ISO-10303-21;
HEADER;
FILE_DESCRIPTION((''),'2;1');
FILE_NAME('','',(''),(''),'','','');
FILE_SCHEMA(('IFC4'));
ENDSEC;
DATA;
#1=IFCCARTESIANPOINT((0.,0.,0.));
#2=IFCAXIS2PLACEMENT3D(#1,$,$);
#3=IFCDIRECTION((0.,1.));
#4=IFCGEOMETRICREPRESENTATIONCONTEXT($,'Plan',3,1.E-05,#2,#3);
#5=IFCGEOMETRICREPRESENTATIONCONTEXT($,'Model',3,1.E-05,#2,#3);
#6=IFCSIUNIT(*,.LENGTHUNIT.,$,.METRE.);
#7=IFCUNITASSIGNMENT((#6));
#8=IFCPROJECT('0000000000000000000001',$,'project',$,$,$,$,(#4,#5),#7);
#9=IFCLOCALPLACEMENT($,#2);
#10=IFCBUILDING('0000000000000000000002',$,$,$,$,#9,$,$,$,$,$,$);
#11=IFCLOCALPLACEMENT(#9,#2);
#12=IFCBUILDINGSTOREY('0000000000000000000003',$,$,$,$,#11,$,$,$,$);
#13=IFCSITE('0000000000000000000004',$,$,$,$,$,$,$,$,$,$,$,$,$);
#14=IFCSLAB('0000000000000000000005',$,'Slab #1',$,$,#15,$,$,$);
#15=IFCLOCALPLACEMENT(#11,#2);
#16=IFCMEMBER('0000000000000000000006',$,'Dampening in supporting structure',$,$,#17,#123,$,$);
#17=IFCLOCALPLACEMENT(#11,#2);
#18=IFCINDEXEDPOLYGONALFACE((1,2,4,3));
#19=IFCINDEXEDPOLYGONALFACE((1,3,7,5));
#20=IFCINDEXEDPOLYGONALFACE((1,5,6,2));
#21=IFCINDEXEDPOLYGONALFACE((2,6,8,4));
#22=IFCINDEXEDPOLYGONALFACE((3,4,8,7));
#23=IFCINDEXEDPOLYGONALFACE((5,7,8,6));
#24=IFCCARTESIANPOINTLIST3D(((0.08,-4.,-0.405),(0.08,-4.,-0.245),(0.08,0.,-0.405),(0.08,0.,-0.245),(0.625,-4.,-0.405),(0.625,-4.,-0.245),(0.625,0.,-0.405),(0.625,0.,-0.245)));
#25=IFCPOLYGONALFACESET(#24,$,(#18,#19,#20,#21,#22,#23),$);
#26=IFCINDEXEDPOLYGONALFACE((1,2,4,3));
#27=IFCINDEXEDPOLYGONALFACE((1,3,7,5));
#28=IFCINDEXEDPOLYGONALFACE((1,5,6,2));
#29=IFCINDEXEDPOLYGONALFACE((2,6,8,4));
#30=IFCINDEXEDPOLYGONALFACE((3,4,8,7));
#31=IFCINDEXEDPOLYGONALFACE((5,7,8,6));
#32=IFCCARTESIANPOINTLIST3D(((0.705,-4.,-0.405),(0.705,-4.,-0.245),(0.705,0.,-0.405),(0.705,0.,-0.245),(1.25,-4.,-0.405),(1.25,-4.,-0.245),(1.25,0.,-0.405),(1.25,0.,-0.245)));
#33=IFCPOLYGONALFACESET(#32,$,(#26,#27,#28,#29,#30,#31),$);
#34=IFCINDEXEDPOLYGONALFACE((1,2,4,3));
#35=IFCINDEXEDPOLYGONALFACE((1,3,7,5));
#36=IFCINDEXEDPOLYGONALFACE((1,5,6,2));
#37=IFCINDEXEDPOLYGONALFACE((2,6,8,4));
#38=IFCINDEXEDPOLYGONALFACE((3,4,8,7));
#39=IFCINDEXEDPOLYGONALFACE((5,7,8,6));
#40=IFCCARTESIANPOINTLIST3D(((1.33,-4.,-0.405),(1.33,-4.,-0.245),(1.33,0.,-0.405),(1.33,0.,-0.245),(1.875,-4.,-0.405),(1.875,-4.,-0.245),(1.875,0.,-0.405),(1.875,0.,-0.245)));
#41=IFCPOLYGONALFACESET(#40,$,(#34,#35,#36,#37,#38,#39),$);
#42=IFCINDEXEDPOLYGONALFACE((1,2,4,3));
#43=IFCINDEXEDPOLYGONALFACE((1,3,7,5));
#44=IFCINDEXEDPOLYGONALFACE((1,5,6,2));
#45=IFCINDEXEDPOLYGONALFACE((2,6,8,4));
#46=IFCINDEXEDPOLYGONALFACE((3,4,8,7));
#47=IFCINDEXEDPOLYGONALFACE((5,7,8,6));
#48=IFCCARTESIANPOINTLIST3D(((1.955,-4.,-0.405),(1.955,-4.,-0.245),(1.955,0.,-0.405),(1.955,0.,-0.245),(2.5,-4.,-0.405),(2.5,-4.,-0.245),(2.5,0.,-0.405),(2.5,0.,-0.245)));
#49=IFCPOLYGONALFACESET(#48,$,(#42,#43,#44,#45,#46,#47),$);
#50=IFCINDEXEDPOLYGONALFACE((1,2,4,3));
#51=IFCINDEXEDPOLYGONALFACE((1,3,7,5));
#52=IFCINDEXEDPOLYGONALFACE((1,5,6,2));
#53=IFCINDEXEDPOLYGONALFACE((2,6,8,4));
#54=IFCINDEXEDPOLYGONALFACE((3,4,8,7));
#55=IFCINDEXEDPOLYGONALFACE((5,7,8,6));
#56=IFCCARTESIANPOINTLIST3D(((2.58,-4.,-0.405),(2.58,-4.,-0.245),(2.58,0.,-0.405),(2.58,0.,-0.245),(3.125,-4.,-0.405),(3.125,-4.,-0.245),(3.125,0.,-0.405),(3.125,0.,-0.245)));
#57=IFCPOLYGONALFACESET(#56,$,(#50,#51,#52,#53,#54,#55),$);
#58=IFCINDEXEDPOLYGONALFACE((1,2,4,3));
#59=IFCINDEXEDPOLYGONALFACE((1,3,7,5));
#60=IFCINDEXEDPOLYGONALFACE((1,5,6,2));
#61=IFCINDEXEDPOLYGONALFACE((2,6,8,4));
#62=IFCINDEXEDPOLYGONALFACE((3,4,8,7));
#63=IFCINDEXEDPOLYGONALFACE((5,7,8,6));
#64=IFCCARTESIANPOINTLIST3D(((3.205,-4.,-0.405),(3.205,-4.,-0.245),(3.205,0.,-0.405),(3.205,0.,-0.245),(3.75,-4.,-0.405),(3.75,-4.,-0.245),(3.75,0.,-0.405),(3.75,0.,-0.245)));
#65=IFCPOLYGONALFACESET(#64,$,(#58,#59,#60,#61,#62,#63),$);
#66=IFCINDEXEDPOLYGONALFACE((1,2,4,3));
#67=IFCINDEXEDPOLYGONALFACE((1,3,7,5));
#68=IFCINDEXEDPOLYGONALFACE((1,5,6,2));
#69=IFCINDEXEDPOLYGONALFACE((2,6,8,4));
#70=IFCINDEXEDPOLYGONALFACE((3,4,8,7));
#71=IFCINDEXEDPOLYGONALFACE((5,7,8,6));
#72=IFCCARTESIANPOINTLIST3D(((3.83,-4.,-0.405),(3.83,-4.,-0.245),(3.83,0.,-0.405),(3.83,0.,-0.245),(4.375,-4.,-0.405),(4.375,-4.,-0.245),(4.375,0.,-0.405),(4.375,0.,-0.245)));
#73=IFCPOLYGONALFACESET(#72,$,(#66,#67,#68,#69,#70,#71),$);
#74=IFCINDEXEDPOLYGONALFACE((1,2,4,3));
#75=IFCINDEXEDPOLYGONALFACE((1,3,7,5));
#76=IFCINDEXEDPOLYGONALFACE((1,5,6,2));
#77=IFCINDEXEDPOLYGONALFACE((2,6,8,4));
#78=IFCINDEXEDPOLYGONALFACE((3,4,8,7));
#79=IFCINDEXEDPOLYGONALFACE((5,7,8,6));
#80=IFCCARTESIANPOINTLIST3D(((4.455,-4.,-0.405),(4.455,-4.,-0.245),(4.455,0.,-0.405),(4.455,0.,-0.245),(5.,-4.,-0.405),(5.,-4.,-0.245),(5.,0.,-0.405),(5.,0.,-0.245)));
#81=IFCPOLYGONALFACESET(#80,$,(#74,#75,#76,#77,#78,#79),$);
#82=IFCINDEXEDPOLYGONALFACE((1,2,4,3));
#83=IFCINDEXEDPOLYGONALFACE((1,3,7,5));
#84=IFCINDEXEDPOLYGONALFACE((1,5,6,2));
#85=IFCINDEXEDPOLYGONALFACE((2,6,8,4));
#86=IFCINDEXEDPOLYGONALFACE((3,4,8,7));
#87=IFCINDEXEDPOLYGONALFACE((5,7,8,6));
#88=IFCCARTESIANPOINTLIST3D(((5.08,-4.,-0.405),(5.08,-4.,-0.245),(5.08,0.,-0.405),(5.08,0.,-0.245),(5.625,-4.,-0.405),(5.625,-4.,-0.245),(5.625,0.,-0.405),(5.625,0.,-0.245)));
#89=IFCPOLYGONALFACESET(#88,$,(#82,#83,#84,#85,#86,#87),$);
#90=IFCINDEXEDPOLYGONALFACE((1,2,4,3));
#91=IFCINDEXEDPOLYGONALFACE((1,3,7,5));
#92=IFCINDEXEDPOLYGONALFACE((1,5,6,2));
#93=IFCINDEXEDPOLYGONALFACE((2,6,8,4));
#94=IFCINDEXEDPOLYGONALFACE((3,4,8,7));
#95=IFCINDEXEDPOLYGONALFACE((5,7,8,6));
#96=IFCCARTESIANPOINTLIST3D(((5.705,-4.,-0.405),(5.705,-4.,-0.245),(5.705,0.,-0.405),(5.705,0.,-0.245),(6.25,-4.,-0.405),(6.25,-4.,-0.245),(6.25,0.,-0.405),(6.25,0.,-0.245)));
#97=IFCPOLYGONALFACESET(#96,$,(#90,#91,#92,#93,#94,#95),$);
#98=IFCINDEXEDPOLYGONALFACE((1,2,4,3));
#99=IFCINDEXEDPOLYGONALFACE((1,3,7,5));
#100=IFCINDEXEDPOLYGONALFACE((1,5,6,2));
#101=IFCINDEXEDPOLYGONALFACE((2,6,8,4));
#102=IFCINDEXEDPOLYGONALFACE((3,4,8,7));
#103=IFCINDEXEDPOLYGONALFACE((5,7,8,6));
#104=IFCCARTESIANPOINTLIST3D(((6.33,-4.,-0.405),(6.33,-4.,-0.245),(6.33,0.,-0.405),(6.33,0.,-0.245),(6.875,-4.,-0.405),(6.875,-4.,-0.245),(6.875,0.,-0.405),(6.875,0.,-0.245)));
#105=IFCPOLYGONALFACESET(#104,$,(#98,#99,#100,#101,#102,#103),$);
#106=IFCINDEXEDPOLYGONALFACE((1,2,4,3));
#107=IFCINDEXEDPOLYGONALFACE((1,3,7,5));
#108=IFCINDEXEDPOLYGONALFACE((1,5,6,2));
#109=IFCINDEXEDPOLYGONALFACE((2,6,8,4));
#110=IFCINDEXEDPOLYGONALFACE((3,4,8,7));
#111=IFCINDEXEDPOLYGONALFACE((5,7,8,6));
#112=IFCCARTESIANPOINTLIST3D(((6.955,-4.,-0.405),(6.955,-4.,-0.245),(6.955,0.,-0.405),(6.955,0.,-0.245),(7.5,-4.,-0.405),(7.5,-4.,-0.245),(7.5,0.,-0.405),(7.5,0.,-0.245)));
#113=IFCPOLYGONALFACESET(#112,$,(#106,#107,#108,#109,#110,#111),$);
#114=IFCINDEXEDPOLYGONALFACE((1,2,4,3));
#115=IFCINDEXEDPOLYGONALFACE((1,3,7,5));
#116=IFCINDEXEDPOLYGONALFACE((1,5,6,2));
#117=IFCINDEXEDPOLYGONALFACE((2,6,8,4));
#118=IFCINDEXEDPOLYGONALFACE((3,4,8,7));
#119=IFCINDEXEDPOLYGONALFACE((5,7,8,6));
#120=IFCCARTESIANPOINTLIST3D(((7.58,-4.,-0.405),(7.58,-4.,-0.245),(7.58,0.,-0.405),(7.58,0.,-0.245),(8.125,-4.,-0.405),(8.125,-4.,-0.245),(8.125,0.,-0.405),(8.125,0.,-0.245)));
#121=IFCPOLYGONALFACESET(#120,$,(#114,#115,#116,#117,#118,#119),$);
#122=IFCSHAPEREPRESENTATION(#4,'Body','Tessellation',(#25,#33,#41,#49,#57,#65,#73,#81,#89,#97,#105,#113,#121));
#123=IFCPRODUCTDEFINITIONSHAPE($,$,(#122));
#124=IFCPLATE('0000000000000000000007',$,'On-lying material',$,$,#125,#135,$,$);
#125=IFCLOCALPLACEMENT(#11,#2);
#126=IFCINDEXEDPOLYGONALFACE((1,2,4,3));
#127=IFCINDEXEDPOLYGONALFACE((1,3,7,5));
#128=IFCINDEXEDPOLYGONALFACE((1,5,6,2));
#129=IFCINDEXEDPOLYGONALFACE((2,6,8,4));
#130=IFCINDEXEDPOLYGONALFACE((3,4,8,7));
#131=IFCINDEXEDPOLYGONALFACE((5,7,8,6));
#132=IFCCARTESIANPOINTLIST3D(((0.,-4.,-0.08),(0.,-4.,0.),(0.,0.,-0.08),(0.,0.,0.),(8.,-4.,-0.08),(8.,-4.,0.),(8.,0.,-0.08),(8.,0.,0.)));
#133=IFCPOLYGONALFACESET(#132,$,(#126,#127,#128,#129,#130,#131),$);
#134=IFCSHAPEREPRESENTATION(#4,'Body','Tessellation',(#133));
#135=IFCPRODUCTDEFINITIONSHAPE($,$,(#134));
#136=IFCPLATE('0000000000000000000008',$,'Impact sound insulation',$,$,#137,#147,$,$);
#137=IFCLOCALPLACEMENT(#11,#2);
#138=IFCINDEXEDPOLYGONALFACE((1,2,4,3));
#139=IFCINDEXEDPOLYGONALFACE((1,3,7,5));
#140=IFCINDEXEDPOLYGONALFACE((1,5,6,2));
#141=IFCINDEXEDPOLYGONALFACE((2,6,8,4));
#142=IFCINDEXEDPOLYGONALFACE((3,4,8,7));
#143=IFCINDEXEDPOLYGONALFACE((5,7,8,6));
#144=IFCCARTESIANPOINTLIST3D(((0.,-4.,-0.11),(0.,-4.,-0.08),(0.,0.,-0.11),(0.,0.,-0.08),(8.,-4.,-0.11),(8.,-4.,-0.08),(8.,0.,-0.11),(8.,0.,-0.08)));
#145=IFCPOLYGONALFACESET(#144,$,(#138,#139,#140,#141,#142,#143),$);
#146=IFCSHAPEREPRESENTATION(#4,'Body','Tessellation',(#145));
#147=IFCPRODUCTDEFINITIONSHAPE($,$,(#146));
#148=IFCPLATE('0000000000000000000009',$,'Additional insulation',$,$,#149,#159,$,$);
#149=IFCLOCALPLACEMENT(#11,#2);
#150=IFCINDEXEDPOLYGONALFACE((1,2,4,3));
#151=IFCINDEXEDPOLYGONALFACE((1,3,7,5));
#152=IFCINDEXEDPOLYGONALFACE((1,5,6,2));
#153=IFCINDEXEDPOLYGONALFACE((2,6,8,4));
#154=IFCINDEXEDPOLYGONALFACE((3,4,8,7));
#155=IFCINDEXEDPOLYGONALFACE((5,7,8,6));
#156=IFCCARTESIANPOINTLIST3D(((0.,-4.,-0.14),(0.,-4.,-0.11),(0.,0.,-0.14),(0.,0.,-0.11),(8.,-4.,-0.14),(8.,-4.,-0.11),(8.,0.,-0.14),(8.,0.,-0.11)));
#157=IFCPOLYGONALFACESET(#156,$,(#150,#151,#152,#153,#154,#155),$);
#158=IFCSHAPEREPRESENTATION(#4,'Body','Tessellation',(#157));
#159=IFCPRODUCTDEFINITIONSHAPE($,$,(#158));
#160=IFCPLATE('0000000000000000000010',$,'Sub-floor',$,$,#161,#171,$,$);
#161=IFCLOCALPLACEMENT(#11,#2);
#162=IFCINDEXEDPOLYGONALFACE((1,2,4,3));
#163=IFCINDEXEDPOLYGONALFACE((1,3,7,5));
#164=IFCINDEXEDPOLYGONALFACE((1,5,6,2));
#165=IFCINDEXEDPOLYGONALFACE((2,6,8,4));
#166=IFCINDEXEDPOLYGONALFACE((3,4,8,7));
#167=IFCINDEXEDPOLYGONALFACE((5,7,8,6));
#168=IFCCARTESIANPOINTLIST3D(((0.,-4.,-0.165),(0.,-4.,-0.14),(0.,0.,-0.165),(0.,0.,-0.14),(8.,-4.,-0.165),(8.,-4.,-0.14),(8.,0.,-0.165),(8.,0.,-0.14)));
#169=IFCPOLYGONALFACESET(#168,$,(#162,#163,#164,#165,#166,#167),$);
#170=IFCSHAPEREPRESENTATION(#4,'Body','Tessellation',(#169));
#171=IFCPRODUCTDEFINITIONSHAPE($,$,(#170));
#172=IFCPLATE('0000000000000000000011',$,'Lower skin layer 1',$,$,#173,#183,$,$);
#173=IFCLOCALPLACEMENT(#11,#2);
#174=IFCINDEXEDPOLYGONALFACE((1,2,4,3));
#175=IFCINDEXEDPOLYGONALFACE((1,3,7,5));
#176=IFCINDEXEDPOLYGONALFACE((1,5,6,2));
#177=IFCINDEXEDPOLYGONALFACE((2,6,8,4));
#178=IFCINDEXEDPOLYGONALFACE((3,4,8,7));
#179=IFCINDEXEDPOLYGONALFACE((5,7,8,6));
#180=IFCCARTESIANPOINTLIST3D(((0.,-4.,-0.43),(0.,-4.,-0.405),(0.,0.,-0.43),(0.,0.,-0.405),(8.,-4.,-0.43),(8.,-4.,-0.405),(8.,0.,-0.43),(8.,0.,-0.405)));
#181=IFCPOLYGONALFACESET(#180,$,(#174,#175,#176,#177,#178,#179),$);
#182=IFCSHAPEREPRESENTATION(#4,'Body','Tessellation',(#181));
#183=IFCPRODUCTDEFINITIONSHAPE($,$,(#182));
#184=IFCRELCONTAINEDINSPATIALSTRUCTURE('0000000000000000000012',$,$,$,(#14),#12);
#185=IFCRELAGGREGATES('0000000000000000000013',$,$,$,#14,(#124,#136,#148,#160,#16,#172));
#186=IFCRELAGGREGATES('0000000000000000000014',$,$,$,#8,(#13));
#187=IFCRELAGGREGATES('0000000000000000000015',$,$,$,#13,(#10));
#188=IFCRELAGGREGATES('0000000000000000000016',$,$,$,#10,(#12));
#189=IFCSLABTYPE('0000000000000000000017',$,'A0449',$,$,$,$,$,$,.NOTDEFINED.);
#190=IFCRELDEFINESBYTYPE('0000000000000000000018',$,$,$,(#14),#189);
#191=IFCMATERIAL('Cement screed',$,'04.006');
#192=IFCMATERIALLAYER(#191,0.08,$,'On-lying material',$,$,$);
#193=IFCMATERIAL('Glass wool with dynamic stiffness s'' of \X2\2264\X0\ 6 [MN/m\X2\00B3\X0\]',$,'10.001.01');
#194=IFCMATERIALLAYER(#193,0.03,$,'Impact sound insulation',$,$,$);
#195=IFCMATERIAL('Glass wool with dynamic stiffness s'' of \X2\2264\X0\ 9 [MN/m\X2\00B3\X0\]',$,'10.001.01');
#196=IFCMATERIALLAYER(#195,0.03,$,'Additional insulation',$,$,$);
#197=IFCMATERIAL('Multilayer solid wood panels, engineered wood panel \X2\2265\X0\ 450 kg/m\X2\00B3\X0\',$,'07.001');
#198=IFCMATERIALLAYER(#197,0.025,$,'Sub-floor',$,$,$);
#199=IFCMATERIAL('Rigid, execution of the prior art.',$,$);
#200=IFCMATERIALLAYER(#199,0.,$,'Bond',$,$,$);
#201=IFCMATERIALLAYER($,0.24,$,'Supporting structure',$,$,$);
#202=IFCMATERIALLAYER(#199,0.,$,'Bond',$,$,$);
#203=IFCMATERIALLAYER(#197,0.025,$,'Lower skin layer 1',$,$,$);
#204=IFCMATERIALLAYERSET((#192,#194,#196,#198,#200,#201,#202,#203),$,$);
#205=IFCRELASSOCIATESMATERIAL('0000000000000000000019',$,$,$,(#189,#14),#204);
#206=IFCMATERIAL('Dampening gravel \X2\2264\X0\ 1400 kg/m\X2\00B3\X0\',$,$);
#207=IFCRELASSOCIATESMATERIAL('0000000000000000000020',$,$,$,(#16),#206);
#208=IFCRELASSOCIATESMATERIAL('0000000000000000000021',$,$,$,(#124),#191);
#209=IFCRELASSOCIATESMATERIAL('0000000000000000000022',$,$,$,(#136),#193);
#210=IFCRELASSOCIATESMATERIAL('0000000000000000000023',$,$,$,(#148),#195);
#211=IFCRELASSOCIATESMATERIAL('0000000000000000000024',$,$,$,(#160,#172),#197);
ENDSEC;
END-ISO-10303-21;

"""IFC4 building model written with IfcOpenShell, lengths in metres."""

from ifc_helpers import new_model, si_unit, direction, frame, frame_2d, origin, origin_with_axes, place, context, project, spatial, rectangle, extrude, material, layer, layer_set, type_object, element, aggregate, save


model = new_model("IFC4")

# Units and contexts
plan_context = context("Plan", 3, precision=1e-05, world=origin(), true_north=direction((0.0, 1.0)))
model_context = context("Model", 3, precision=1e-05, world=origin(), true_north=direction((0.0, 1.0)))
ifc_project = project(units=[si_unit("LENGTHUNIT", "METRE")], contexts=[plan_context, model_context])

# Site, building, storey
site = spatial("IfcSite", under=ifc_project)
building_placement = place(None, origin())
building = spatial("IfcBuilding", under=site, at=building_placement)
storey_placement = place(building_placement, origin())
storey = spatial("IfcBuildingStorey", under=building, at=storey_placement)

# Slab, member, plates
ifc_material_1 = material(Name="Cement screed", Category="04.006")
ifc_layer_1 = layer(ifc_material_1, 0.08, Name="On-lying material")
ifc_material_2 = material(Name="Glass wool with dynamic stiffness s' of ≤ 6 [MN/m³]", Category="10.001.01")
ifc_layer_2 = layer(ifc_material_2, 0.03, Name="Impact sound insulation")
ifc_material_3 = material(Name="Glass wool with dynamic stiffness s' of ≤ 9 [MN/m³]", Category="10.001.01")
ifc_layer_3 = layer(ifc_material_3, 0.03, Name="Additional insulation")
ifc_material_4 = material(Name="Multilayer solid wood panels, engineered wood panel ≥ 450 kg/m³", Category="07.001")
ifc_layer_4 = layer(ifc_material_4, 0.025, Name="Sub-floor")
ifc_material_5 = material(Name="Rigid, execution of the prior art.")
ifc_layer_5 = layer(ifc_material_5, 0.0, Name="Bond")
ifc_layer_6 = layer(None, 0.24, Name="Supporting structure")
ifc_layer_7 = layer(ifc_material_5, 0.0, Name="Bond")
ifc_layer_8 = layer(ifc_material_4, 0.025, Name="Lower skin layer 1")
ifc_layer_set = layer_set([ifc_layer_1, ifc_layer_2, ifc_layer_3, ifc_layer_4, ifc_layer_5, ifc_layer_6, ifc_layer_7, ifc_layer_8])
slab_type = type_object("IfcSlabType", Name="A0449", PredefinedType="NOTDEFINED", material=ifc_layer_set)
slab_placement = place(None, frame((0.0, 0.0, 0.0), z_axis=(0.0, 0.0, -1.0), x_axis=(1.0, 0.0, 0.0)))
slab = element("IfcSlab", 1, at=slab_placement, inside=storey, type_object=slab_type, material=ifc_layer_set, Name="Slab #1")
ifc_material_6 = material(Name="Dampening gravel ≤ 1400 kg/m³")
member_1_placement = place(slab_placement, origin())
member_1 = element("IfcMember", 2, at=member_1_placement, material=ifc_material_6, Name="Dampening in supporting structure", context=plan_context, shape_type="SweptSolid", body=[
    extrude(rectangle(XDim=0.545, YDim=0.16, at=frame_2d((0.2725, 0.08), x_axis=(1.0, 0.0))), frame((0.08, 4.0, 0.245), z_axis=(0.0, -1.0, 0.0), x_axis=(1.0, 0.0, 0.0)), (0.0, 0.0, 1.0), 4.0),
    extrude(rectangle(XDim=0.545, YDim=0.16, at=frame_2d((0.2725, 0.08), x_axis=(1.0, 0.0))), frame((0.705, 4.0, 0.245), z_axis=(0.0, -1.0, 0.0), x_axis=(1.0, 0.0, 0.0)), (0.0, 0.0, 1.0), 4.0),
    extrude(rectangle(XDim=0.545, YDim=0.16, at=frame_2d((0.2725, 0.08), x_axis=(1.0, 0.0))), frame((1.33, 4.0, 0.245), z_axis=(0.0, -1.0, 0.0), x_axis=(1.0, 0.0, 0.0)), (0.0, 0.0, 1.0), 4.0),
    extrude(rectangle(XDim=0.545, YDim=0.16, at=frame_2d((0.2725, 0.08), x_axis=(1.0, 0.0))), frame((1.955, 4.0, 0.245), z_axis=(0.0, -1.0, 0.0), x_axis=(1.0, 0.0, 0.0)), (0.0, 0.0, 1.0), 4.0),
    extrude(rectangle(XDim=0.545, YDim=0.16, at=frame_2d((0.2725, 0.08), x_axis=(1.0, 0.0))), frame((2.58, 4.0, 0.245), z_axis=(0.0, -1.0, 0.0), x_axis=(1.0, 0.0, 0.0)), (0.0, 0.0, 1.0), 4.0),
    extrude(rectangle(XDim=0.545, YDim=0.16, at=frame_2d((0.2725, 0.08), x_axis=(1.0, 0.0))), frame((3.205, 4.0, 0.245), z_axis=(0.0, -1.0, 0.0), x_axis=(1.0, 0.0, 0.0)), (0.0, 0.0, 1.0), 4.0),
    extrude(rectangle(XDim=0.545, YDim=0.16, at=frame_2d((0.2725, 0.08), x_axis=(1.0, 0.0))), frame((3.83, 4.0, 0.245), z_axis=(0.0, -1.0, 0.0), x_axis=(1.0, 0.0, 0.0)), (0.0, 0.0, 1.0), 4.0),
    extrude(rectangle(XDim=0.545, YDim=0.16, at=frame_2d((0.2725, 0.08), x_axis=(1.0, 0.0))), frame((4.455, 4.0, 0.245), z_axis=(0.0, -1.0, 0.0), x_axis=(1.0, 0.0, 0.0)), (0.0, 0.0, 1.0), 4.0),
    extrude(rectangle(XDim=0.545, YDim=0.16, at=frame_2d((0.2725, 0.08), x_axis=(1.0, 0.0))), frame((5.08, 4.0, 0.245), z_axis=(0.0, -1.0, 0.0), x_axis=(1.0, 0.0, 0.0)), (0.0, 0.0, 1.0), 4.0),
    extrude(rectangle(XDim=0.545, YDim=0.16, at=frame_2d((0.2725, 0.08), x_axis=(1.0, 0.0))), frame((5.705, 4.0, 0.245), z_axis=(0.0, -1.0, 0.0), x_axis=(1.0, 0.0, 0.0)), (0.0, 0.0, 1.0), 4.0),
    extrude(rectangle(XDim=0.545, YDim=0.16, at=frame_2d((0.2725, 0.08), x_axis=(1.0, 0.0))), frame((6.33, 4.0, 0.245), z_axis=(0.0, -1.0, 0.0), x_axis=(1.0, 0.0, 0.0)), (0.0, 0.0, 1.0), 4.0),
    extrude(rectangle(XDim=0.545, YDim=0.16, at=frame_2d((0.2725, 0.08), x_axis=(1.0, 0.0))), frame((6.955, 4.0, 0.245), z_axis=(0.0, -1.0, 0.0), x_axis=(1.0, 0.0, 0.0)), (0.0, 0.0, 1.0), 4.0),
    extrude(rectangle(XDim=0.545, YDim=0.16, at=frame_2d((0.2725, 0.08), x_axis=(1.0, 0.0))), frame((7.58, 4.0, 0.245), z_axis=(0.0, -1.0, 0.0), x_axis=(1.0, 0.0, 0.0)), (0.0, 0.0, 1.0), 4.0),
])
plate_1_placement = place(slab_placement, origin())
plate_1 = element("IfcPlate", 3, at=plate_1_placement, material=ifc_material_1, Name="On-lying material", context=plan_context, shape_type="SweptSolid", body=[
    extrude(rectangle(XDim=8.0, YDim=4.0, at=frame_2d((4.0, 2.0), x_axis=(1.0, 0.0))), origin_with_axes(), (0.0, 0.0, 1.0), 0.08),
])
plate_2_placement = place(slab_placement, origin())
plate_2 = element("IfcPlate", 4, at=plate_2_placement, material=ifc_material_2, Name="Impact sound insulation", context=plan_context, shape_type="SweptSolid", body=[
    extrude(rectangle(XDim=8.0, YDim=4.0, at=frame_2d((4.0, 2.0), x_axis=(1.0, 0.0))), frame((0.0, 0.0, 0.08), z_axis=(0.0, 0.0, 1.0), x_axis=(1.0, 0.0, 0.0)), (0.0, 0.0, 1.0), 0.03),
])
plate_3_placement = place(slab_placement, origin())
plate_3 = element("IfcPlate", 5, at=plate_3_placement, material=ifc_material_3, Name="Additional insulation", context=plan_context, shape_type="SweptSolid", body=[
    extrude(rectangle(XDim=8.0, YDim=4.0, at=frame_2d((4.0, 2.0), x_axis=(1.0, 0.0))), frame((0.0, 0.0, 0.11), z_axis=(0.0, 0.0, 1.0), x_axis=(1.0, 0.0, 0.0)), (0.0, 0.0, 1.0), 0.03),
])
plate_4_placement = place(slab_placement, origin())
plate_4 = element("IfcPlate", 6, at=plate_4_placement, material=ifc_material_4, Name="Sub-floor", context=plan_context, shape_type="SweptSolid", body=[
    extrude(rectangle(XDim=8.0, YDim=4.0, at=frame_2d((4.0, 2.0), x_axis=(1.0, 0.0))), frame((0.0, 0.0, 0.14), z_axis=(0.0, 0.0, 1.0), x_axis=(1.0, 0.0, 0.0)), (0.0, 0.0, 1.0), 0.025),
])
plate_5_placement = place(slab_placement, origin())
plate_5 = element("IfcPlate", 7, at=plate_5_placement, material=ifc_material_4, Name="Lower skin layer 1", context=plan_context, shape_type="SweptSolid", body=[
    extrude(rectangle(XDim=8.0, YDim=4.0, at=frame_2d((4.0, 2.0), x_axis=(1.0, 0.0))), frame((0.0, 0.0, 0.405), z_axis=(0.0, 0.0, 1.0), x_axis=(1.0, 0.0, 0.0)), (0.0, 0.0, 1.0), 0.025),
])
aggregate(slab, [plate_1, plate_2, plate_3, plate_4, member_1, plate_5])

save(model, "model.ifc")
